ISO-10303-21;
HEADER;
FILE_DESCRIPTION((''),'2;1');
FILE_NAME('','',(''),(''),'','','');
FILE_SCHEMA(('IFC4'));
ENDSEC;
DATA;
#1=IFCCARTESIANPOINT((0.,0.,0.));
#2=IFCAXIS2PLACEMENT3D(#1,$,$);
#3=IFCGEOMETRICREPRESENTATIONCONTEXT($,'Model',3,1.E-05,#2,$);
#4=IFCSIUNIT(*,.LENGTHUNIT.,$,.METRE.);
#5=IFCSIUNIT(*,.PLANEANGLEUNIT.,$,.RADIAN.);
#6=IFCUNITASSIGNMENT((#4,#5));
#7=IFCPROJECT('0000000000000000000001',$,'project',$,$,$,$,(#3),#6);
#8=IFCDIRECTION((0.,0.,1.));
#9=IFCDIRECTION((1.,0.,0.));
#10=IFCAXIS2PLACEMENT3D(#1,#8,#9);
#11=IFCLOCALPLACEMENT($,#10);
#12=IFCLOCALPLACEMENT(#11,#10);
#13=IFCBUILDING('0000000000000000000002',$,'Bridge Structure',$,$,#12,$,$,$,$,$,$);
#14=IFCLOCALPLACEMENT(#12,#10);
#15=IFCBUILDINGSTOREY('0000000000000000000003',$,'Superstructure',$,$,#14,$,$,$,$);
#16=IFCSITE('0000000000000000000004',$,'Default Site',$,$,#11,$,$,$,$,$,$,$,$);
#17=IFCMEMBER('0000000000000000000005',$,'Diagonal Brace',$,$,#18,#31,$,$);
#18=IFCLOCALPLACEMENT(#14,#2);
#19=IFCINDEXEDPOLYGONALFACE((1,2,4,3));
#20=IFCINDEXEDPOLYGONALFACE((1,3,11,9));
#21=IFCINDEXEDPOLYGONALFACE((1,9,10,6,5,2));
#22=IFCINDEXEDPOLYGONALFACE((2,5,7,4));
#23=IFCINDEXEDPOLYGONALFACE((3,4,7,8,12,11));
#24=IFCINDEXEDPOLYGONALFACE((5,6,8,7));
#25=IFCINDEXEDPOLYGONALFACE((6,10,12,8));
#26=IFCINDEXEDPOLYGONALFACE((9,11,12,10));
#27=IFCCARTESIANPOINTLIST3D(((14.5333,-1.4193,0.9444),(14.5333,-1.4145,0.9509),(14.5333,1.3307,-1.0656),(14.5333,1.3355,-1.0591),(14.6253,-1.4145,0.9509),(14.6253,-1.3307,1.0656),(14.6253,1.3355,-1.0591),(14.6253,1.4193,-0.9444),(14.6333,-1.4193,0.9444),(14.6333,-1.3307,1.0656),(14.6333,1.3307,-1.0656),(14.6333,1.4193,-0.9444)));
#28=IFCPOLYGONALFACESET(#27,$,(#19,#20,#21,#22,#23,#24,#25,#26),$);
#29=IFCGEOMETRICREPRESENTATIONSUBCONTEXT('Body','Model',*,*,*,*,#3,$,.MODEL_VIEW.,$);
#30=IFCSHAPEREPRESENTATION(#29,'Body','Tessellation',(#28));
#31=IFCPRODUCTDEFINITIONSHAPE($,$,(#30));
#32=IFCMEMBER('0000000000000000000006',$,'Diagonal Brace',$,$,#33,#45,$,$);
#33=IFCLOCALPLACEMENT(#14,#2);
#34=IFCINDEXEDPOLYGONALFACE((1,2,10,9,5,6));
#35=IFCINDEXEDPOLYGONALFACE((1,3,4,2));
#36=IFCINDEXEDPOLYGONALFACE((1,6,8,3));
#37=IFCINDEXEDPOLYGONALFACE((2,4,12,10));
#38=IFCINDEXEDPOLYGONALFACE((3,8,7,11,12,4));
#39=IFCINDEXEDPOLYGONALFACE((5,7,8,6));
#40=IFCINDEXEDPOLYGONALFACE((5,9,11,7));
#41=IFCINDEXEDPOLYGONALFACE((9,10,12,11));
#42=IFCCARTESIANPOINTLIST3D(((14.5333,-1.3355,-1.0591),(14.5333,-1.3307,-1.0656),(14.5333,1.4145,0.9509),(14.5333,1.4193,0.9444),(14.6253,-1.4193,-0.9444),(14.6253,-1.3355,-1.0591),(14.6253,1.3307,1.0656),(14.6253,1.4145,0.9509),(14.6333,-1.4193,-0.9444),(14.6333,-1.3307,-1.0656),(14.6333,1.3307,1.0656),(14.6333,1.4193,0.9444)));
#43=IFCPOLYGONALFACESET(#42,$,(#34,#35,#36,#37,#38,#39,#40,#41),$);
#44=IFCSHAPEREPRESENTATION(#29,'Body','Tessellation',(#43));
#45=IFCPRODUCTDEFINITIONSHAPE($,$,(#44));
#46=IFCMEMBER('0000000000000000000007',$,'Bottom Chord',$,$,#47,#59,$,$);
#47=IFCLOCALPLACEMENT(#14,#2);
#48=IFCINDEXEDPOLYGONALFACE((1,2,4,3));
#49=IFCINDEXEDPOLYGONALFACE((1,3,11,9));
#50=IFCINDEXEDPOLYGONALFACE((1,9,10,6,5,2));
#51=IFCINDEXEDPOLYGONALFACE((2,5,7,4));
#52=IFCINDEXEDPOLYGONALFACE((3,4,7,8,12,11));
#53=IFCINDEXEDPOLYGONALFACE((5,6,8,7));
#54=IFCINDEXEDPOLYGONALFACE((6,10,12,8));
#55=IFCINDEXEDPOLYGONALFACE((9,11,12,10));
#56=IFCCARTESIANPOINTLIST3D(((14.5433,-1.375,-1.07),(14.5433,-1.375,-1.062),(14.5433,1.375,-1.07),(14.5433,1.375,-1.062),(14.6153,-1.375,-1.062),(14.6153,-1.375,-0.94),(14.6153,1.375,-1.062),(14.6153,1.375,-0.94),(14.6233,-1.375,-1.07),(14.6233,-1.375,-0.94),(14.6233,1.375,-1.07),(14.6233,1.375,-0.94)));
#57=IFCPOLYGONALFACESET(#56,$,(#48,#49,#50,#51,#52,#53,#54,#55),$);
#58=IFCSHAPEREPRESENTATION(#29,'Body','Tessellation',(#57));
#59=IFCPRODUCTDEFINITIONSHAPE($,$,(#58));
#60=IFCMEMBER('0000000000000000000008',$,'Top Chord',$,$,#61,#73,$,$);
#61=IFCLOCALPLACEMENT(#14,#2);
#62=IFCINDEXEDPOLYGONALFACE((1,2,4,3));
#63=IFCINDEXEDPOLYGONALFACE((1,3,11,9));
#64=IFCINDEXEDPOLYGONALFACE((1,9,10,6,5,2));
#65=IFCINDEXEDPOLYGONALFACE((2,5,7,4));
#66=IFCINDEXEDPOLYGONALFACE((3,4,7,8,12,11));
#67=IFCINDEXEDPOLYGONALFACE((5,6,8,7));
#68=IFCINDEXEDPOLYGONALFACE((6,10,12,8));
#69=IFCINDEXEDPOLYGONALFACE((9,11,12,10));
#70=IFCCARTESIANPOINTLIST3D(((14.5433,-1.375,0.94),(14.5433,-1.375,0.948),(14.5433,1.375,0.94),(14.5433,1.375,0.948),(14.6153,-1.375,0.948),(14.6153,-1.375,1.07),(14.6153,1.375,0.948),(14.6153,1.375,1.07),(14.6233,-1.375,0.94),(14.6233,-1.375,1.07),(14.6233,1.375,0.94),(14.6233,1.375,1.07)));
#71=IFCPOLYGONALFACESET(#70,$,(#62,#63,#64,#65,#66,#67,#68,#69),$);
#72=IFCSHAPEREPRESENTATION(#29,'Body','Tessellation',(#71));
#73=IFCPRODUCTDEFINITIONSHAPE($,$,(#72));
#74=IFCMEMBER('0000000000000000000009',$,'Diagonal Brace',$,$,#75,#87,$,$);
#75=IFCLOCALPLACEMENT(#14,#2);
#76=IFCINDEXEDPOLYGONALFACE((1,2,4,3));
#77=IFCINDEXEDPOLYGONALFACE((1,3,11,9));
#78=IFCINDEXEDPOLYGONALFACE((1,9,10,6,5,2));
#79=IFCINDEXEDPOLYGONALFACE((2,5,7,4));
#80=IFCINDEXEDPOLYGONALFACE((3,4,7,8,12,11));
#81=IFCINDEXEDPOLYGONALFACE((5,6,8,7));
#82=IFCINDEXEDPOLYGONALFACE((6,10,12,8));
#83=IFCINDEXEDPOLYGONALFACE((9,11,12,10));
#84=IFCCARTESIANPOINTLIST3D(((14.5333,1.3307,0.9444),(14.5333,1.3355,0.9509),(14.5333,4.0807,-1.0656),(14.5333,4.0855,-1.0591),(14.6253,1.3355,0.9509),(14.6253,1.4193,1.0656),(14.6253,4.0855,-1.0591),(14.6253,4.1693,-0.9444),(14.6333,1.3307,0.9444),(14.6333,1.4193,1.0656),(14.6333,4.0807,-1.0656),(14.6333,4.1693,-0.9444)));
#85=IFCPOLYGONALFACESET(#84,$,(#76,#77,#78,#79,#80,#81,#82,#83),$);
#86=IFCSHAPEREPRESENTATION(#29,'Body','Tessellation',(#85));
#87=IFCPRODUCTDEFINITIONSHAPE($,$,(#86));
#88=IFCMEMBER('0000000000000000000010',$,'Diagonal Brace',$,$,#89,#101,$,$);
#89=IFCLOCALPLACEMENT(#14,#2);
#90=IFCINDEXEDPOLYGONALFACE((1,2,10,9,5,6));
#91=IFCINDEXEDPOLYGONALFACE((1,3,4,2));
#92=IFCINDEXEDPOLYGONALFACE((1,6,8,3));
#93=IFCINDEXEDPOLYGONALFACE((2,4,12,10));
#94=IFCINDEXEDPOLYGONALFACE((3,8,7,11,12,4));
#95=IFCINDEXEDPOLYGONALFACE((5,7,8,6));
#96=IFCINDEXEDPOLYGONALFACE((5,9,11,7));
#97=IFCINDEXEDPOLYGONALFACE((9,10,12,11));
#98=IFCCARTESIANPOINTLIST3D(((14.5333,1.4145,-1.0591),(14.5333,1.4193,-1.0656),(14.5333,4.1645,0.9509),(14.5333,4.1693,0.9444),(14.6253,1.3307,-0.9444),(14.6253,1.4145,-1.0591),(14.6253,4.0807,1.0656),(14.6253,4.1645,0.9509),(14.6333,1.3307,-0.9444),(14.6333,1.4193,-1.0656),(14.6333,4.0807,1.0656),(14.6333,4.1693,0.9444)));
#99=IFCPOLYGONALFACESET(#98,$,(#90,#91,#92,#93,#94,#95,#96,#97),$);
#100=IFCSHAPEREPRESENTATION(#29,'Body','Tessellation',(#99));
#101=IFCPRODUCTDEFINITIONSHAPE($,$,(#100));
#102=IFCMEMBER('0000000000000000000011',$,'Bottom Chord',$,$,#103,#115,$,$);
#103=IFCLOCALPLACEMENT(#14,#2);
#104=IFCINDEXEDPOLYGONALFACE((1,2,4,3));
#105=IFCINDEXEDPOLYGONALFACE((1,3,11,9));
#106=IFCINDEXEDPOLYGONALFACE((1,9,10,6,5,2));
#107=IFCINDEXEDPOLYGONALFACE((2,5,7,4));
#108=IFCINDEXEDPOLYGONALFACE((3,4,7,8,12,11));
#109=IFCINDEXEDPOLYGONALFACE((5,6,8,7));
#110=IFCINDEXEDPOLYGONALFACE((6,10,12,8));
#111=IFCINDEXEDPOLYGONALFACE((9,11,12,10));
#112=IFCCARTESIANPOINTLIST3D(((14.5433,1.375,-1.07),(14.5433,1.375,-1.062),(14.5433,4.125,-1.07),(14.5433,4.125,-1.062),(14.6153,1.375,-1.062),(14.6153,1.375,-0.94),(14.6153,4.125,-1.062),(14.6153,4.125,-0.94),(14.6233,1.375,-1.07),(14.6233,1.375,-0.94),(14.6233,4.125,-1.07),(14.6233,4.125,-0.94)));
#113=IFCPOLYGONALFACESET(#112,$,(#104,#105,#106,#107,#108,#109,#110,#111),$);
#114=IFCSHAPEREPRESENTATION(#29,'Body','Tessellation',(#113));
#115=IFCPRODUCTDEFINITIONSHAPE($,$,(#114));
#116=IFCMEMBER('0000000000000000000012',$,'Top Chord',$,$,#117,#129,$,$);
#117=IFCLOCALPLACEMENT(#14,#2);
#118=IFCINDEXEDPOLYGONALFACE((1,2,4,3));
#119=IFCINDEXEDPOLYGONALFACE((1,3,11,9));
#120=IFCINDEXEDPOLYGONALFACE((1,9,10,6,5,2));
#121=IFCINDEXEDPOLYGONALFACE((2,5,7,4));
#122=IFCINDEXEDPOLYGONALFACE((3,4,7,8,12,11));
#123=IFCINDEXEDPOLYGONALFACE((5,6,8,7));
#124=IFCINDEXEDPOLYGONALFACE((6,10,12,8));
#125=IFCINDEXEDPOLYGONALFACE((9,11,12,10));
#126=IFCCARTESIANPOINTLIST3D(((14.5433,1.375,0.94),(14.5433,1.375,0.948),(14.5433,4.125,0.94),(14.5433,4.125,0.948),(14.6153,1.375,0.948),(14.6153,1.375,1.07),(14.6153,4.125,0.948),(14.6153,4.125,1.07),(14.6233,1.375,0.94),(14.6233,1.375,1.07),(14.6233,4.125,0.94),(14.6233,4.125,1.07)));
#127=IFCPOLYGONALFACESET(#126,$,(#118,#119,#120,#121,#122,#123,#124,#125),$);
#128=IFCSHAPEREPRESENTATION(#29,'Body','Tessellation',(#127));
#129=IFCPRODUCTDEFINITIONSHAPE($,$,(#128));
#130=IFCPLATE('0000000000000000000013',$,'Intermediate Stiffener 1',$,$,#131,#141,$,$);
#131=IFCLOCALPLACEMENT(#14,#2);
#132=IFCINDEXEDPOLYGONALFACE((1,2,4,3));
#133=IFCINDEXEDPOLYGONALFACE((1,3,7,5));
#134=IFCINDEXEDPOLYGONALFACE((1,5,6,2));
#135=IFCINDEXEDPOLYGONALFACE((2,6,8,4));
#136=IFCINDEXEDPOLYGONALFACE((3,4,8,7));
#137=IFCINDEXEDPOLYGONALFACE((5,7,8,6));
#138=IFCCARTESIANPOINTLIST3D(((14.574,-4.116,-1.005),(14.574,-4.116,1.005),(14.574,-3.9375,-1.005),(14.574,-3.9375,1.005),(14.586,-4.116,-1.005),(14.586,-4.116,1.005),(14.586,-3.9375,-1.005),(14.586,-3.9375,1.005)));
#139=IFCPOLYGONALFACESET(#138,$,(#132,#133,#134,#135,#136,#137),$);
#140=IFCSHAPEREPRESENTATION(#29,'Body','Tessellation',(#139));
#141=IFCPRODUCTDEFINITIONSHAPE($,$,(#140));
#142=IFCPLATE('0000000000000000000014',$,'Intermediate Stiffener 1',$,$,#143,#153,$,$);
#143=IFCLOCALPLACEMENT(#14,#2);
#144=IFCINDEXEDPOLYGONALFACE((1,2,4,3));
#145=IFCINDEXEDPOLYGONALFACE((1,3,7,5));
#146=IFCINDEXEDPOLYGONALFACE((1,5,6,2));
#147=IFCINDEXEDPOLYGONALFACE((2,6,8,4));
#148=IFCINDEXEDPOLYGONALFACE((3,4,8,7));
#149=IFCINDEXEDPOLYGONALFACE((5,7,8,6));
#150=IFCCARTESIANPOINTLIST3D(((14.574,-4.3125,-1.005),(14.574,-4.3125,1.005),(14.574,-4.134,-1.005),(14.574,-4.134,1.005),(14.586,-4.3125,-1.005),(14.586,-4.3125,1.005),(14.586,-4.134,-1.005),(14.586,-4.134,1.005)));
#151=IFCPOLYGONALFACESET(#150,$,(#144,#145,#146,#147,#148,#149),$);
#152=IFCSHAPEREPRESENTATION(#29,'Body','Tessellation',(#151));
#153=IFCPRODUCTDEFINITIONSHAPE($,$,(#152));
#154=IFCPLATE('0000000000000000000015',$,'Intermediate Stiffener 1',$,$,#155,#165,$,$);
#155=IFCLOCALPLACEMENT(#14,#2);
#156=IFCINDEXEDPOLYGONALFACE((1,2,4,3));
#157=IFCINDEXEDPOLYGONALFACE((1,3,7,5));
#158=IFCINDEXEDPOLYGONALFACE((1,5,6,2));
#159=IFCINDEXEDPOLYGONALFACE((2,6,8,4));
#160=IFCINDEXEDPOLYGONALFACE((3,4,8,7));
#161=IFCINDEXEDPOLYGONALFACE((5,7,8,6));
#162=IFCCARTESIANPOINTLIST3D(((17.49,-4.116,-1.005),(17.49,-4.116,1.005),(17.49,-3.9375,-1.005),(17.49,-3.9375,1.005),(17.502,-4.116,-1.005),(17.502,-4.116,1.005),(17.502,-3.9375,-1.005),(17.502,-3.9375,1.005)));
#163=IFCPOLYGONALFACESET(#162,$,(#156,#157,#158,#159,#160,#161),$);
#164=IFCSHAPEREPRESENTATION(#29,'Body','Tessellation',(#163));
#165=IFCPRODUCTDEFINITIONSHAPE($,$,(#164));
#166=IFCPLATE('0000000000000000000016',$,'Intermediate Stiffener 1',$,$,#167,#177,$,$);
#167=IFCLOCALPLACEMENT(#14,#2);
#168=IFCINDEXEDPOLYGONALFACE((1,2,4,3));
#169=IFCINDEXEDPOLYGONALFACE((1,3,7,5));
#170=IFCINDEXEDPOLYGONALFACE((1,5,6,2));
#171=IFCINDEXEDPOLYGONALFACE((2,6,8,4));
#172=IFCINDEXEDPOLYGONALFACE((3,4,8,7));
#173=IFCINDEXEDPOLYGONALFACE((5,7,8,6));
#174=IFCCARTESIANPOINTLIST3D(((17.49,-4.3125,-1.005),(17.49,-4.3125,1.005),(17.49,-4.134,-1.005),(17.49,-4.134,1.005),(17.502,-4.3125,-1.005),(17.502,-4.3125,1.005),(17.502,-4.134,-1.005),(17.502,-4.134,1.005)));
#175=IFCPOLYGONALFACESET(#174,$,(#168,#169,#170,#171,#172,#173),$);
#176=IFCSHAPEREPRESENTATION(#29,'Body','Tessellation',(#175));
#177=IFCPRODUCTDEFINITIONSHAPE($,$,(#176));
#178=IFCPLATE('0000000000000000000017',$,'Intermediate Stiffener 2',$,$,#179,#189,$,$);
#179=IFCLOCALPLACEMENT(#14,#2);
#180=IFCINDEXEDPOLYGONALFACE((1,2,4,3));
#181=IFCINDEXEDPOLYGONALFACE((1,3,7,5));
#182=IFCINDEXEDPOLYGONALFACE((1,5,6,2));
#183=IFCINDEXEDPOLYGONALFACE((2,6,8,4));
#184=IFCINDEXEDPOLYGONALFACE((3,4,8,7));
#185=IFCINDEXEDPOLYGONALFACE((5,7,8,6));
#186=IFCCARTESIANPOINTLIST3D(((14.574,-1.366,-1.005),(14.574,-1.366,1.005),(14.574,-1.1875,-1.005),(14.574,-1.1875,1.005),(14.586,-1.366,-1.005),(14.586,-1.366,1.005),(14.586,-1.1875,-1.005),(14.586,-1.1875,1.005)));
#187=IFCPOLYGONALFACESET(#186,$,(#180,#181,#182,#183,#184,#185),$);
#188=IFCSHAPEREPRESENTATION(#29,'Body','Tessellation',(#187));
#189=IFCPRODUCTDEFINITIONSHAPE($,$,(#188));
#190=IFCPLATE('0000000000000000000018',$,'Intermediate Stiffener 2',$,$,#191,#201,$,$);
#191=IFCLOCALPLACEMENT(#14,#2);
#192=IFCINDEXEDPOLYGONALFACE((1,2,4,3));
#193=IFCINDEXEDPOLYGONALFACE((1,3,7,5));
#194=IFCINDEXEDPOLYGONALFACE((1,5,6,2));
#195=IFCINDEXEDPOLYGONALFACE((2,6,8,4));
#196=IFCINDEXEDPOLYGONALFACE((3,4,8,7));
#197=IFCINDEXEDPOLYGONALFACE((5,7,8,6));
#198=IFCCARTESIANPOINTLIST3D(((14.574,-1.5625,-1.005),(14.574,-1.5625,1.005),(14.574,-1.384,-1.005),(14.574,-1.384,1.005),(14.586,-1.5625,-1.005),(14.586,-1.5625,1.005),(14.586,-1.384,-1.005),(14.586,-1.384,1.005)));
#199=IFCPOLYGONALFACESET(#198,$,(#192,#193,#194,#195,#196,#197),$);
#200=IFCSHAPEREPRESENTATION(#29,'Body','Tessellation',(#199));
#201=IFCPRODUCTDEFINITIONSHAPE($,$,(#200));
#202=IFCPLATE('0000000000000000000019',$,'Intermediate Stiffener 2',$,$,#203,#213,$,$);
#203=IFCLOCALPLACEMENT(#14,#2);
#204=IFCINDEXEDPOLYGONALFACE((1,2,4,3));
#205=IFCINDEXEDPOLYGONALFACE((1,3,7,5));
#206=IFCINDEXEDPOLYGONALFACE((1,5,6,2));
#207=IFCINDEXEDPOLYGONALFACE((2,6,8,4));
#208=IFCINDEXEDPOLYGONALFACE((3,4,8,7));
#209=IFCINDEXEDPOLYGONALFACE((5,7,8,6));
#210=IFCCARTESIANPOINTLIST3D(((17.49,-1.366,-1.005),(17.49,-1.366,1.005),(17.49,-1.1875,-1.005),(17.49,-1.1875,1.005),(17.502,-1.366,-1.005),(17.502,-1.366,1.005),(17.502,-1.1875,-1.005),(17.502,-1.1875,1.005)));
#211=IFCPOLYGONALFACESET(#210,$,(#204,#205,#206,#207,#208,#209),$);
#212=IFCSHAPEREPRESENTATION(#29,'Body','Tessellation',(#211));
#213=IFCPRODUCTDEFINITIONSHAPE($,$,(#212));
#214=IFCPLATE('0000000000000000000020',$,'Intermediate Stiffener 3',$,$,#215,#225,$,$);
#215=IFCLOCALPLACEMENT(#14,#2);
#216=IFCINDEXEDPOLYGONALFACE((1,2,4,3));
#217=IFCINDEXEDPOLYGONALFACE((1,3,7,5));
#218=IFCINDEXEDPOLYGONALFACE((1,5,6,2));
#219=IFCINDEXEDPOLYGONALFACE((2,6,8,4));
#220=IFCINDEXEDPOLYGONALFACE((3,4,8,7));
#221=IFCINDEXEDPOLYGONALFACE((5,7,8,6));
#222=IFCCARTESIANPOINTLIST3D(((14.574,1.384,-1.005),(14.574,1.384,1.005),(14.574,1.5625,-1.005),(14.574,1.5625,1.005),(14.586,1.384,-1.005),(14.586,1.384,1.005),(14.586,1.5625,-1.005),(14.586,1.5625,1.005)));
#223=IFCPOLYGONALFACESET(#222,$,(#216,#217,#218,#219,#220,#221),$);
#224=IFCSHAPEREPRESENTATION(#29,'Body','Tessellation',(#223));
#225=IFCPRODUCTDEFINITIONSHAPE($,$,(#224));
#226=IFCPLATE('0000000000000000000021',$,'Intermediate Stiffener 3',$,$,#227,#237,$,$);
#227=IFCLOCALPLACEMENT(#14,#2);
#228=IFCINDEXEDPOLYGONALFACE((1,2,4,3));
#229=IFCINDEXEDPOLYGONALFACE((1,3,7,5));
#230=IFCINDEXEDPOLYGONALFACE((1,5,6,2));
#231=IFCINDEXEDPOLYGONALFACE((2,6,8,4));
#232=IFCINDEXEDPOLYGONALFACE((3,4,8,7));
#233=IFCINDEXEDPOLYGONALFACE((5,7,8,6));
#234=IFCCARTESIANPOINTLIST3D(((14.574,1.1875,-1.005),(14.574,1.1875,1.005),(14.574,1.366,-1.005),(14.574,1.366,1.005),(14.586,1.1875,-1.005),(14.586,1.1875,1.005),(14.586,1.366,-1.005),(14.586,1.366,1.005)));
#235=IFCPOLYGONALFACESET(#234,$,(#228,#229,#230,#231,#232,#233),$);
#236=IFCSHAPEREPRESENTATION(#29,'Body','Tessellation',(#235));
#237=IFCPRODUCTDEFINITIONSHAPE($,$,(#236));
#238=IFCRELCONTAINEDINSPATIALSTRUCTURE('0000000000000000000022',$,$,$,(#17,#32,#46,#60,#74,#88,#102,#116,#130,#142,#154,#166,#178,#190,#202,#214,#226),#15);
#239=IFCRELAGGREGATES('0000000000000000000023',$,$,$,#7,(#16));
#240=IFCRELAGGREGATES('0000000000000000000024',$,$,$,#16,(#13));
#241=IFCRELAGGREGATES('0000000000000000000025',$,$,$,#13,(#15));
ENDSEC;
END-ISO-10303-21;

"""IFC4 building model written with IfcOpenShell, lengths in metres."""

from ifc_helpers import new_model, si_unit, frame, origin, origin_with_axes, origin_2d_with_axis, place, context, subcontext, project, spatial, rectangle, l_section, extrude, element, save


model = new_model("IFC4")

# Units and contexts
model_context = context("Model", 3, precision=1e-05, world=origin())
body_context = subcontext(model_context, "Body", "Model", "MODEL_VIEW")
ifc_project = project(units=[si_unit("LENGTHUNIT", "METRE"), si_unit("PLANEANGLEUNIT", "RADIAN")], contexts=[model_context])

# Site, building, storey
site_placement = place(None, origin_with_axes())
site = spatial("IfcSite", under=ifc_project, at=site_placement, Name="Default Site")
building_placement = place(site_placement, origin_with_axes())
building = spatial("IfcBuilding", under=site, at=building_placement, Name="Bridge Structure")
storey_placement = place(building_placement, origin_with_axes())
storey = spatial("IfcBuildingStorey", under=building, at=storey_placement, Name="Superstructure")

# Members
for number, where, z_axis, x_axis, name in (
    (1, (14.5833, -1.375, 1.005), (0.0, 0.807337, -0.59009), (-1.0, 0.0, 0.0), "Diagonal Brace"),
    (2, (14.5833, -1.375, -1.005), (0.0, 0.807337, 0.59009), (-1.0, 0.0, 0.0), "Diagonal Brace"),
):
    element("IfcMember", number, at=place(storey_placement, frame(where, z_axis=z_axis, x_axis=x_axis)), inside=storey, Name=name, context=body_context, shape_type="SweptSolid", body=[
        extrude(l_section(Depth=0.15, Width=0.1, Thickness=0.008, at=origin_2d_with_axis()), origin_with_axes(), (0.0, 0.0, 1.0), 3.4063),
    ])
for number, where, z_axis, x_axis, name in (
    (3, (14.5833, -1.375, -1.005), (0.0, 1.0, 0.0), (-1.0, 0.0, 0.0), "Bottom Chord"),
    (4, (14.5833, -1.375, 1.005), (0.0, 1.0, 0.0), (-1.0, 0.0, 0.0), "Top Chord"),
):
    element("IfcMember", number, at=place(storey_placement, frame(where, z_axis=z_axis, x_axis=x_axis)), inside=storey, Name=name, context=body_context, shape_type="SweptSolid", body=[
        extrude(l_section(Depth=0.13, Width=0.08, Thickness=0.008, at=origin_2d_with_axis()), origin_with_axes(), (0.0, 0.0, 1.0), 2.75),
    ])
for number, where, z_axis, x_axis, name in (
    (5, (14.5833, 1.375, 1.005), (0.0, 0.807337, -0.59009), (-1.0, 0.0, 0.0), "Diagonal Brace"),
    (6, (14.5833, 1.375, -1.005), (0.0, 0.807337, 0.59009), (-1.0, 0.0, 0.0), "Diagonal Brace"),
):
    element("IfcMember", number, at=place(storey_placement, frame(where, z_axis=z_axis, x_axis=x_axis)), inside=storey, Name=name, context=body_context, shape_type="SweptSolid", body=[
        extrude(l_section(Depth=0.15, Width=0.1, Thickness=0.008, at=origin_2d_with_axis()), origin_with_axes(), (0.0, 0.0, 1.0), 3.4063),
    ])
for number, where, z_axis, x_axis, name in (
    (7, (14.5833, 1.375, -1.005), (0.0, 1.0, 0.0), (-1.0, 0.0, 0.0), "Bottom Chord"),
    (8, (14.5833, 1.375, 1.005), (0.0, 1.0, 0.0), (-1.0, 0.0, 0.0), "Top Chord"),
):
    element("IfcMember", number, at=place(storey_placement, frame(where, z_axis=z_axis, x_axis=x_axis)), inside=storey, Name=name, context=body_context, shape_type="SweptSolid", body=[
        extrude(l_section(Depth=0.13, Width=0.08, Thickness=0.008, at=origin_2d_with_axis()), origin_with_axes(), (0.0, 0.0, 1.0), 2.75),
    ])

# Plates
for number, where, z_axis, x_axis, name in (
    (9, (14.58, -4.0267, -1.005), (0.0, 0.0, 1.0), (1.0, 0.0, 0.0), "Intermediate Stiffener 1"),
    (10, (14.58, -4.2233, -1.005), (0.0, 0.0, 1.0), (1.0, 0.0, 0.0), "Intermediate Stiffener 1"),
    (11, (17.496, -4.0267, -1.005), (0.0, 0.0, 1.0), (1.0, 0.0, 0.0), "Intermediate Stiffener 1"),
    (12, (17.496, -4.2233, -1.005), (0.0, 0.0, 1.0), (1.0, 0.0, 0.0), "Intermediate Stiffener 1"),
    (13, (14.58, -1.2768, -1.005), (0.0, 0.0, 1.0), (1.0, 0.0, 0.0), "Intermediate Stiffener 2"),
    (14, (14.58, -1.4732, -1.005), (0.0, 0.0, 1.0), (1.0, 0.0, 0.0), "Intermediate Stiffener 2"),
    (15, (17.496, -1.2768, -1.005), (0.0, 0.0, 1.0), (1.0, 0.0, 0.0), "Intermediate Stiffener 2"),
    (16, (14.58, 1.4732, -1.005), (0.0, 0.0, 1.0), (1.0, 0.0, 0.0), "Intermediate Stiffener 3"),
    (17, (14.58, 1.2768, -1.005), (0.0, 0.0, 1.0), (1.0, 0.0, 0.0), "Intermediate Stiffener 3"),
):
    element("IfcPlate", number, at=place(storey_placement, frame(where, z_axis=z_axis, x_axis=x_axis)), inside=storey, Name=name, context=body_context, shape_type="SweptSolid", body=[
        extrude(rectangle(XDim=0.012, YDim=0.1785, at=origin_2d_with_axis()), origin_with_axes(), (0.0, 0.0, 1.0), 2.01),
    ])

save(model, "model.ifc")
